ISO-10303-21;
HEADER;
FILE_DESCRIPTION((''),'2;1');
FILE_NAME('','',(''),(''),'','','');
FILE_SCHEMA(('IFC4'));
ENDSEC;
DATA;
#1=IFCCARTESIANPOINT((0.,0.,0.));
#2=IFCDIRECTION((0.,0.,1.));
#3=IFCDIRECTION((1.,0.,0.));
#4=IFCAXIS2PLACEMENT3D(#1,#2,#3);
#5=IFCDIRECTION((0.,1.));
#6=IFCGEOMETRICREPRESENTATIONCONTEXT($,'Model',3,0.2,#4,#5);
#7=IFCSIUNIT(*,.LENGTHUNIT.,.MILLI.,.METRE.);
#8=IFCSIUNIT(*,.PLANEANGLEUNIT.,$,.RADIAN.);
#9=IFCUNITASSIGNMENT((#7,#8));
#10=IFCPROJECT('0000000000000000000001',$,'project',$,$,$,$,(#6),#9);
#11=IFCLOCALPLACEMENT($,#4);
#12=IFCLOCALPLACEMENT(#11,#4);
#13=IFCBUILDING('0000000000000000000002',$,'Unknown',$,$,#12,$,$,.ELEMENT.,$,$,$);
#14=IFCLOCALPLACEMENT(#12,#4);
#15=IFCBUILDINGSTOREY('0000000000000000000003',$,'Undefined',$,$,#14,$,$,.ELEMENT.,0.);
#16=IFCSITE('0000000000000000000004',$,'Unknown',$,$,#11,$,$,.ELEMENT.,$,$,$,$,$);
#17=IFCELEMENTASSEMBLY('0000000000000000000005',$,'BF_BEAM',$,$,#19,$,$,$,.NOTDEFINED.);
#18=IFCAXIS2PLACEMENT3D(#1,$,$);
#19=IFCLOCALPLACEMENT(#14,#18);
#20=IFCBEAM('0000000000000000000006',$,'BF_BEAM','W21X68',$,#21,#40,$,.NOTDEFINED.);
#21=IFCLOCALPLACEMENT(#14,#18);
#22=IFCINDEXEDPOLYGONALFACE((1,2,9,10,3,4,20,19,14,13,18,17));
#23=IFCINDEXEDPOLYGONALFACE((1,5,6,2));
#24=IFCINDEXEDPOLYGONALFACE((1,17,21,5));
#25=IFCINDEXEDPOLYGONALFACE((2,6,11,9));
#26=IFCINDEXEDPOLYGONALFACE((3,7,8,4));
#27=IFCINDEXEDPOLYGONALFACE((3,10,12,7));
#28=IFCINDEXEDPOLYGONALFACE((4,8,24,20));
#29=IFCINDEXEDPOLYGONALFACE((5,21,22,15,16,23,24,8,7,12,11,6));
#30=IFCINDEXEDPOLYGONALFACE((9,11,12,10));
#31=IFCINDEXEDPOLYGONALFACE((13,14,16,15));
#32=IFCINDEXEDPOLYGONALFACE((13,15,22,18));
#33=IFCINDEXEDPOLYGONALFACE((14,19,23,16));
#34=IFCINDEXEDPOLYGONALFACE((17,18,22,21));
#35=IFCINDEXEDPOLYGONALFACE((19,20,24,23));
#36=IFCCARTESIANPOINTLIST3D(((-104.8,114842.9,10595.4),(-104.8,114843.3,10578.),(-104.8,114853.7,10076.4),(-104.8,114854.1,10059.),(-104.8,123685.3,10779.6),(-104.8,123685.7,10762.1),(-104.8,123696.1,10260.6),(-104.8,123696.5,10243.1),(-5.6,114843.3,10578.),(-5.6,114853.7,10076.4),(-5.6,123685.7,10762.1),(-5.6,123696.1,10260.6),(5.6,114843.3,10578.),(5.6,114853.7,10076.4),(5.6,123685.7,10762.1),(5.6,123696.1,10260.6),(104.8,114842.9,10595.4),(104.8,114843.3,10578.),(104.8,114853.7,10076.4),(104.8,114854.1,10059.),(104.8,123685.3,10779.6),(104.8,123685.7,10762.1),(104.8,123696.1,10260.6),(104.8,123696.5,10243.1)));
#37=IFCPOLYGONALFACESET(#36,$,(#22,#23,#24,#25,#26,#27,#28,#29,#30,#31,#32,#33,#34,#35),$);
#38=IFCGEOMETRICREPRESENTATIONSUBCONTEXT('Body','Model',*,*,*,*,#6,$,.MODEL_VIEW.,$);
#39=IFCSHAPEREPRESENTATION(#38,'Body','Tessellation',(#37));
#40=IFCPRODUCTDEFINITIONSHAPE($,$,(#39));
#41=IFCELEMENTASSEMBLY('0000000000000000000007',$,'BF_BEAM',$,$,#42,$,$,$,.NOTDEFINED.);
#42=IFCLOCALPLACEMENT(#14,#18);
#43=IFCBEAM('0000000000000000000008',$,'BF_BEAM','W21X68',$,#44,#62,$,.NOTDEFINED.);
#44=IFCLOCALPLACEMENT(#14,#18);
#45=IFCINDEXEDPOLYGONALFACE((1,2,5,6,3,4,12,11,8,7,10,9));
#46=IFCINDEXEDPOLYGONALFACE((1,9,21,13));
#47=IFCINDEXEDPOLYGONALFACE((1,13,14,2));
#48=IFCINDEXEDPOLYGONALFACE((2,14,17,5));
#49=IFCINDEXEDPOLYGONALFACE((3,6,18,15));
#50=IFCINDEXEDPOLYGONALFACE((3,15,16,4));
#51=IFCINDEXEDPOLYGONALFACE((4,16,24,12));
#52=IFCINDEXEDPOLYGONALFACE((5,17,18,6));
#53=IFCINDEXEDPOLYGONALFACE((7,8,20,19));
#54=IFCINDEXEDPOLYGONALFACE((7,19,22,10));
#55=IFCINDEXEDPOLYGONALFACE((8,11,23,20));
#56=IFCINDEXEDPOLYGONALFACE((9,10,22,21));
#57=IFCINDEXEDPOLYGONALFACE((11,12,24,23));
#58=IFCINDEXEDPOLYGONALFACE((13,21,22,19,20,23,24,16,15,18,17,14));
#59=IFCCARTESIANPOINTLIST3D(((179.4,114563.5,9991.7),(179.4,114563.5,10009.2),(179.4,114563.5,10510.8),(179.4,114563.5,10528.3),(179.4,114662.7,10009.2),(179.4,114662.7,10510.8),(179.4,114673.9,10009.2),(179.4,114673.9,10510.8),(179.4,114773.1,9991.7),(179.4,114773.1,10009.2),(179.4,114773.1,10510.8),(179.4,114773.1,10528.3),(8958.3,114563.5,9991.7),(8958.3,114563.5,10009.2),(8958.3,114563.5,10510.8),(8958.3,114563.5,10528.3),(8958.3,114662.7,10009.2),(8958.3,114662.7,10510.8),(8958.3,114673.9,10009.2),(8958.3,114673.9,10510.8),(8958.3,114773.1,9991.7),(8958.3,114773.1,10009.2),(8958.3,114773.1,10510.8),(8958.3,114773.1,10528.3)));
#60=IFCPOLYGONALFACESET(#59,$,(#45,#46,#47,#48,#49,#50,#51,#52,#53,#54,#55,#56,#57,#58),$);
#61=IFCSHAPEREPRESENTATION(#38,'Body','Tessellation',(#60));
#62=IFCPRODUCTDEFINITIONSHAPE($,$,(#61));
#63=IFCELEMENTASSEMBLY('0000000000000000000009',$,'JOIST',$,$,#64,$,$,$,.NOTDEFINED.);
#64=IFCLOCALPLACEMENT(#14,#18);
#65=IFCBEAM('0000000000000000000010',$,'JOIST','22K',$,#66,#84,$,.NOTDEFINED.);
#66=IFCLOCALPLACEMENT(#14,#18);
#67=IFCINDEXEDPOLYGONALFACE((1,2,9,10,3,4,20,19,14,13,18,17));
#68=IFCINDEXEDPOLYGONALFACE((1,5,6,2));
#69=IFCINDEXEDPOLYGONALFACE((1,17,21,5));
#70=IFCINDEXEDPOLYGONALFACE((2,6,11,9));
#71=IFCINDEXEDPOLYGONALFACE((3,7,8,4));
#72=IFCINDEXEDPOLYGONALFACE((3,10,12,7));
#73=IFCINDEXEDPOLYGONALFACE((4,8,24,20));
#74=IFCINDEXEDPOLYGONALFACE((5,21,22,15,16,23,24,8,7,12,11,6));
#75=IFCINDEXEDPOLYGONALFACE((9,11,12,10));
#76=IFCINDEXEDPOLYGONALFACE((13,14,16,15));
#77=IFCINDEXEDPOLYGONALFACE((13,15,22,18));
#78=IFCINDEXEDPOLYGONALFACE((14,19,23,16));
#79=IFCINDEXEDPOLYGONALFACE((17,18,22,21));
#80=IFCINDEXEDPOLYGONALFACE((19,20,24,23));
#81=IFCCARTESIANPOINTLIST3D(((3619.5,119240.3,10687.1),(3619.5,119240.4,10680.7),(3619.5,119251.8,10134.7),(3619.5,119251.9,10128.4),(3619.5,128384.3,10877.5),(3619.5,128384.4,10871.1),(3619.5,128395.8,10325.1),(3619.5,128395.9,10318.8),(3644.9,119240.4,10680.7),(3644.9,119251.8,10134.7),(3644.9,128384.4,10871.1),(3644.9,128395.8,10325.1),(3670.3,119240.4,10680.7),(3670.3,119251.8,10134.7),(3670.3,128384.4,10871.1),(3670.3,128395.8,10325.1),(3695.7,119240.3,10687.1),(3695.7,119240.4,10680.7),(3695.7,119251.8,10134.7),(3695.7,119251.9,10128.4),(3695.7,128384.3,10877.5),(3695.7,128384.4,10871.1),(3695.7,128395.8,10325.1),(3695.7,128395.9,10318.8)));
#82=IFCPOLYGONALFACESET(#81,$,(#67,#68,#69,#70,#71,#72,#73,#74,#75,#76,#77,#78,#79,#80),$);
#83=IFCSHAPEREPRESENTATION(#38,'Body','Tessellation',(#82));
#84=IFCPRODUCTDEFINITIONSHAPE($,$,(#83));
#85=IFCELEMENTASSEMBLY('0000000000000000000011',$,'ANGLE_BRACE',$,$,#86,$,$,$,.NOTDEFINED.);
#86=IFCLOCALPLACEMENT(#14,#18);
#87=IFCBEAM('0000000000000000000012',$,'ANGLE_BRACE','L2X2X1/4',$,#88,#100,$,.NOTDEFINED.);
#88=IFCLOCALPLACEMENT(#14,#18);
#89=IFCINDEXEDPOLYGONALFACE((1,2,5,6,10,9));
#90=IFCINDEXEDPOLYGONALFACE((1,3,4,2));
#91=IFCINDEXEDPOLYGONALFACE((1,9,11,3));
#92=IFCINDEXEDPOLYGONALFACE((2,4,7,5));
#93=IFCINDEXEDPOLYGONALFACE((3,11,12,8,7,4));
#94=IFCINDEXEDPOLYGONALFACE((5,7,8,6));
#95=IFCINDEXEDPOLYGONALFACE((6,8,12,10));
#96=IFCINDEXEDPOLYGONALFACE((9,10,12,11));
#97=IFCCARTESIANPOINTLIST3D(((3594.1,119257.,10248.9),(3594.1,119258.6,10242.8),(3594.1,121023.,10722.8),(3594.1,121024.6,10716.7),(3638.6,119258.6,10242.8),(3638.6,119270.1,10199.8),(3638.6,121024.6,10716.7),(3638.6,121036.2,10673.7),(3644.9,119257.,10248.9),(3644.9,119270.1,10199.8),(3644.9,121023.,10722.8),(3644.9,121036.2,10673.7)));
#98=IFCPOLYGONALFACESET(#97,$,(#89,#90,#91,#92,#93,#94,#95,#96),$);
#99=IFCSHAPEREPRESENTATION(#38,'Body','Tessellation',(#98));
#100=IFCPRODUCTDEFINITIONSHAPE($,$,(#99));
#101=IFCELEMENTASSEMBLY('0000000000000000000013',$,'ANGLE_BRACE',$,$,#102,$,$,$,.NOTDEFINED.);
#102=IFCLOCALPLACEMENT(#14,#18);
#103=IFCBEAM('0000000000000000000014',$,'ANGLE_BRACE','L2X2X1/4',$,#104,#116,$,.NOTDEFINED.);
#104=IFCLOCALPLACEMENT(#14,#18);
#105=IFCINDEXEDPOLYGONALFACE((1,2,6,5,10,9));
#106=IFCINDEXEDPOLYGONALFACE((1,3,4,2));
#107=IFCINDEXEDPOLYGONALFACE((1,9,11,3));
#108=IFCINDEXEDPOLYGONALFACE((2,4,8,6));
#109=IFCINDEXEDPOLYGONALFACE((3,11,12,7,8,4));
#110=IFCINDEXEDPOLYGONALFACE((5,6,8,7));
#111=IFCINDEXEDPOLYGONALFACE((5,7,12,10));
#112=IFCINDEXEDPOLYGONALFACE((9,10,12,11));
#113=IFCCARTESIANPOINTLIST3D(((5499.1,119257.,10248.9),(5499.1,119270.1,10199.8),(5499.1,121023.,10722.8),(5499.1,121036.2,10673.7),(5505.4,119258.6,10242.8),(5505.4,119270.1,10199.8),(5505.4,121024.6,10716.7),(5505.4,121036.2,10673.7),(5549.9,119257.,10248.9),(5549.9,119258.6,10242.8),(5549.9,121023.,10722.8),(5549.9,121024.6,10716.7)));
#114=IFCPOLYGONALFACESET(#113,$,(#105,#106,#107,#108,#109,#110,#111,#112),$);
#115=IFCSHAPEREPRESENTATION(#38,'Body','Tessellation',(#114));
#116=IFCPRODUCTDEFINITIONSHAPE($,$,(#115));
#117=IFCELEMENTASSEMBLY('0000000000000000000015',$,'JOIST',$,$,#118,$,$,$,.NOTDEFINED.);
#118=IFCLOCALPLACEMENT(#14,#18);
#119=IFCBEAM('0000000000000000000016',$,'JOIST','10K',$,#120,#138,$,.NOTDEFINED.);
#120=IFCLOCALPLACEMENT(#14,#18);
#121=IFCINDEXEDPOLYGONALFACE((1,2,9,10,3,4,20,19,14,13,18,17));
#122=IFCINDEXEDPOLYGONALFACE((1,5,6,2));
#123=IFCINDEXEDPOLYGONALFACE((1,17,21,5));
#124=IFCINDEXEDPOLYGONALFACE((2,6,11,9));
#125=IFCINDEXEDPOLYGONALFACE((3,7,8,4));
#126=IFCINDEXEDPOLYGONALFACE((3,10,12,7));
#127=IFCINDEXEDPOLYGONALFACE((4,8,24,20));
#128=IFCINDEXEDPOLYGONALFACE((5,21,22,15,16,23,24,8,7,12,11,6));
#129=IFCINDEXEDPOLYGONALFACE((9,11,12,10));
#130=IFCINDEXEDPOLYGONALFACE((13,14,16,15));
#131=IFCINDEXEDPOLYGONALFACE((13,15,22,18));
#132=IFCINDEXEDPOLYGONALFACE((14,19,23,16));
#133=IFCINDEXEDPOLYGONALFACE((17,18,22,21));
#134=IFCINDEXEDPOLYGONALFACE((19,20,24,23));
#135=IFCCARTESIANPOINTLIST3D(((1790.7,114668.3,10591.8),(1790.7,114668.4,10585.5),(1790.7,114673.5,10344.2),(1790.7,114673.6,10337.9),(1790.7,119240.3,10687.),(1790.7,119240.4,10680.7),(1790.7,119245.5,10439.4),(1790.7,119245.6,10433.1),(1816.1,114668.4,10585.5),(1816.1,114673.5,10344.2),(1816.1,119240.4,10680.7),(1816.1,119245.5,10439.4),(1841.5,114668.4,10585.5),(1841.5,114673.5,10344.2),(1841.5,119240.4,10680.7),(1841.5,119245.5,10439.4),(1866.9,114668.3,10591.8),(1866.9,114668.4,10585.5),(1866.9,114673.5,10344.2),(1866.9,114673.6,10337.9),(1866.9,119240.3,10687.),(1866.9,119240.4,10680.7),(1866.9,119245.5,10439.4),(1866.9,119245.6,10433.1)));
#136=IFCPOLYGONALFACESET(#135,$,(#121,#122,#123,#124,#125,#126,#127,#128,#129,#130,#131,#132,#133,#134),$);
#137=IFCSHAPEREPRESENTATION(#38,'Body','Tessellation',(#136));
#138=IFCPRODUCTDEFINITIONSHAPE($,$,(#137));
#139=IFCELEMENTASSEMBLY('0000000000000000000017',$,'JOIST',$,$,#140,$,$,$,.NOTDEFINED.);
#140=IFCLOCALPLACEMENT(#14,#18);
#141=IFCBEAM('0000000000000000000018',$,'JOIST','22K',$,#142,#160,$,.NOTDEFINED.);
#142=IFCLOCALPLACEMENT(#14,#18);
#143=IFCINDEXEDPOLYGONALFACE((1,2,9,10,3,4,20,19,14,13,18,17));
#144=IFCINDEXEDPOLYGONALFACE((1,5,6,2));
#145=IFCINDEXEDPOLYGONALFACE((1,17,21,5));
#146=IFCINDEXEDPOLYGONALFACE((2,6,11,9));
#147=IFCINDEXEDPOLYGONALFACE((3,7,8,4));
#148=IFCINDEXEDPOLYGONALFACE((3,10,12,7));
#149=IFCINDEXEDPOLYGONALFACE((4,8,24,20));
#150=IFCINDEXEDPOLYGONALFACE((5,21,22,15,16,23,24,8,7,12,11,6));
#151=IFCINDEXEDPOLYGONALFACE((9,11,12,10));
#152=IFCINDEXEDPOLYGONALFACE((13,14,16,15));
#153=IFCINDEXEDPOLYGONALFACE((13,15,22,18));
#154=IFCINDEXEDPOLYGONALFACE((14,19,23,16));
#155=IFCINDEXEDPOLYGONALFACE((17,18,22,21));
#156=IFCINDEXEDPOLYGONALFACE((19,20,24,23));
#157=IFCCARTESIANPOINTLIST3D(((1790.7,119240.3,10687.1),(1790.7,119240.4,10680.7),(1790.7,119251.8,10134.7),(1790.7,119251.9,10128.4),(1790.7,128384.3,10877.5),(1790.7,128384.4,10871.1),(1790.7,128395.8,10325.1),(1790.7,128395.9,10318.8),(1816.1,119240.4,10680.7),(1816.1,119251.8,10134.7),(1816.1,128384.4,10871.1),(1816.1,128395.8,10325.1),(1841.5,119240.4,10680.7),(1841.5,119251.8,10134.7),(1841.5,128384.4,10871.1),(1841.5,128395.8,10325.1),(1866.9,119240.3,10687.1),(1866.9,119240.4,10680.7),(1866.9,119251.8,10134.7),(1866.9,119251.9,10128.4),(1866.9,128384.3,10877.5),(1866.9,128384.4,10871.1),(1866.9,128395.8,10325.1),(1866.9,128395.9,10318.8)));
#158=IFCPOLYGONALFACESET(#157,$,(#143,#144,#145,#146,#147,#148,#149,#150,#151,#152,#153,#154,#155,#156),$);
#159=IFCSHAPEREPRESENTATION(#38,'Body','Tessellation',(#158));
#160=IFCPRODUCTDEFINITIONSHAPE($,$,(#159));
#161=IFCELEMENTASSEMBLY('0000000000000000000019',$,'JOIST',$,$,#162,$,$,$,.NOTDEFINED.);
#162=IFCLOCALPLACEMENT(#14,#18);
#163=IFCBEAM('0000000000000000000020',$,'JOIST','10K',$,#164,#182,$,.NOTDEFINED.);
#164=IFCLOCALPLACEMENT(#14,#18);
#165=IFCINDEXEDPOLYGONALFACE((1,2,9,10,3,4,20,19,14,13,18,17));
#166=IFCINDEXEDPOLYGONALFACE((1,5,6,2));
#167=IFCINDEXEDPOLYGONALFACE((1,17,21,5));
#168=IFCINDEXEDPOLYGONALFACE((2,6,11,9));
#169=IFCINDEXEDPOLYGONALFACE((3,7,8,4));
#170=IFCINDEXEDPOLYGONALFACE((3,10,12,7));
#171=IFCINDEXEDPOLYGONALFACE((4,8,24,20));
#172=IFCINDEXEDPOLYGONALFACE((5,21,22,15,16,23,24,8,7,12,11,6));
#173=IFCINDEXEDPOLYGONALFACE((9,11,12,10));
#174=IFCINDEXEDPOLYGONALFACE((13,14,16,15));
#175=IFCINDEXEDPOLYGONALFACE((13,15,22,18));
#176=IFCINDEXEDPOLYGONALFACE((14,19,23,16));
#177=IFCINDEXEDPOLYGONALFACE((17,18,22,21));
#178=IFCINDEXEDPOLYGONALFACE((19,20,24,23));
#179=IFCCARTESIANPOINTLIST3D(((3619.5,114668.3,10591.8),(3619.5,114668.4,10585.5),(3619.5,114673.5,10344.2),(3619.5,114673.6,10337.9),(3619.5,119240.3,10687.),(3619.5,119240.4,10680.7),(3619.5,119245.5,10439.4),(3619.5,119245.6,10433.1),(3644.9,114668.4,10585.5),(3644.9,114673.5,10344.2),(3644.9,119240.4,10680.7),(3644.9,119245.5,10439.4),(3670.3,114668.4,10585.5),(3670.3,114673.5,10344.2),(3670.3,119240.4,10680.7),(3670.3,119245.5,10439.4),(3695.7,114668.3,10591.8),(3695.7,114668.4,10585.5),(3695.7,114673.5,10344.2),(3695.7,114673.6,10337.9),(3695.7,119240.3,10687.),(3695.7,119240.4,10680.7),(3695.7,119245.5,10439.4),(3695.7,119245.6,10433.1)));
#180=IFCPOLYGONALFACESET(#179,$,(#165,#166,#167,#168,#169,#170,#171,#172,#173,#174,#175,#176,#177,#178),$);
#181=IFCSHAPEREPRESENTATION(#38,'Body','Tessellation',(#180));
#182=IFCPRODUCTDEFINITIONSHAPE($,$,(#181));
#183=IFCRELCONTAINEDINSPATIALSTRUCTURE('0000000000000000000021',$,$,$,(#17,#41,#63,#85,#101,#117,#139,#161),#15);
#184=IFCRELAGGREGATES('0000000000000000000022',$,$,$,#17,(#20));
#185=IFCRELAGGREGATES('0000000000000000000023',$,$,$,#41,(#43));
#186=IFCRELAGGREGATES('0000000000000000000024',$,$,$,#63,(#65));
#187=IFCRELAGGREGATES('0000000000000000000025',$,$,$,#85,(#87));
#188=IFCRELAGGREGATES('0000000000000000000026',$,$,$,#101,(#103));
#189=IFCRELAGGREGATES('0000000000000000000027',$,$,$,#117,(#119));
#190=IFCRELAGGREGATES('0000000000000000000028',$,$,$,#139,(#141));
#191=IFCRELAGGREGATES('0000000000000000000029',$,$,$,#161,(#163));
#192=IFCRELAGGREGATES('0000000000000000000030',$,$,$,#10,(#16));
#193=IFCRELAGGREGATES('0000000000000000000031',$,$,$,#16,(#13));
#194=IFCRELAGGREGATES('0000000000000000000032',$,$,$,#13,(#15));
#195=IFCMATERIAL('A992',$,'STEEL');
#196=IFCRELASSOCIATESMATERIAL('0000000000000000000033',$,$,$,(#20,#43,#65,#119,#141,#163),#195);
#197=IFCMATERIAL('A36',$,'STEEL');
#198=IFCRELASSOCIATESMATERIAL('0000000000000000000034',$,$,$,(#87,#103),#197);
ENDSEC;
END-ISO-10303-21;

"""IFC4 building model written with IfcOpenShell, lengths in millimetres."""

from ifc_helpers import new_model, si_unit, direction, frame, origin_with_axes, place, context, subcontext, project, spatial, line, indexed_curve, outline, extrude, material, element, aggregate, save


model = new_model("IFC4")

# Units and contexts
model_context = context("Model", 3, precision=0.2, world=origin_with_axes(), true_north=direction((0.0, 1.0)))
body_context = subcontext(model_context, "Body", "Model", "MODEL_VIEW")
ifc_project = project(units=[si_unit("LENGTHUNIT", "METRE", prefix="MILLI"), si_unit("PLANEANGLEUNIT", "RADIAN")], contexts=[model_context])

# Site, building, storey
site_placement = place(None, origin_with_axes())
site = spatial("IfcSite", under=ifc_project, at=site_placement, Name="Unknown", CompositionType="ELEMENT")
building_placement = place(site_placement, origin_with_axes())
building = spatial("IfcBuilding", under=site, at=building_placement, Name="Unknown", CompositionType="ELEMENT")
storey_placement = place(building_placement, origin_with_axes())
storey = spatial("IfcBuildingStorey", under=building, at=storey_placement, Name="Undefined", CompositionType="ELEMENT", Elevation=0.0)

# Element assembly, beam
assembly_1_placement = place(storey_placement, frame((0.0, 114848.5, 10327.2), z_axis=(1.0, 0.0, 0.0), x_axis=(0.0, 0.999783, 0.020819)))
assembly_1 = element("IfcElementAssembly", 1, at=assembly_1_placement, inside=storey, Name="BF_BEAM", PredefinedType="NOTDEFINED")
ifc_material_1 = material(Name="A992", Category="STEEL")
beam_1_placement = place(assembly_1_placement, origin_with_axes())
beam_1 = element("IfcBeam", 2, at=beam_1_placement, material=ifc_material_1, Name="BF_BEAM", Description="W21X68", PredefinedType="NOTDEFINED", context=body_context, shape_type="SolidModel", body=[
    extrude(outline(indexed_curve([(-104.8, -268.3), (104.8, -268.3), (104.8, -250.8), (5.6, -250.8), (5.6, 250.8), (104.8, 250.8), (104.8, 268.3), (-104.8, 268.3), (-104.8, 250.8), (-5.6, 250.8), (-5.6, -250.8), (-104.8, -250.8)], segments=[line(1, 2, 3, 4, 5, 6, 7, 8, 9, 10, 11, 12, 1)])), frame((0.0, 0.0, 0.0), z_axis=(-1.0, 0.0, 0.0), x_axis=(0.0, 0.0, 1.0)), (0.0, 0.0, -1.0), 8844.4),
])
aggregate(assembly_1, [beam_1])

# Element assemblies, beams
assembly_2_placement = place(storey_placement, frame((179.4, 114668.3, 10260.0), z_axis=(0.0, -1.0, 0.0), x_axis=(1.0, 0.0, 0.0)))
assembly_2 = element("IfcElementAssembly", 3, at=assembly_2_placement, inside=storey, Name="BF_BEAM", PredefinedType="NOTDEFINED")
beam_2_placement = place(assembly_2_placement, origin_with_axes())
beam_2 = element("IfcBeam", 4, at=beam_2_placement, material=ifc_material_1, Name="BF_BEAM", Description="W21X68", PredefinedType="NOTDEFINED", context=body_context, shape_type="SolidModel", body=[
    extrude(outline(indexed_curve([(-104.8, -268.3), (104.8, -268.3), (104.8, -250.8), (5.6, -250.8), (5.6, 250.8), (104.8, 250.8), (104.8, 268.3), (-104.8, 268.3), (-104.8, 250.8), (-5.6, 250.8), (-5.6, -250.8), (-104.8, -250.8)], segments=[line(1, 2, 3, 4, 5, 6, 7, 8, 9, 10, 11, 12, 1)])), frame((0.0, 0.0, 0.0), z_axis=(-1.0, 0.0, 0.0), x_axis=(0.0, 0.0, 1.0)), (0.0, 0.0, -1.0), 8778.9),
])
aggregate(assembly_2, [beam_2])
assembly_3_placement = place(storey_placement, frame((3657.6, 119246.1, 10407.7), z_axis=(1.0, 0.0, 0.0), x_axis=(0.0, 0.999783, 0.020819)))
assembly_3 = element("IfcElementAssembly", 5, at=assembly_3_placement, inside=storey, Name="JOIST", PredefinedType="NOTDEFINED")
beam_3_placement = place(assembly_3_placement, origin_with_axes())
beam_3 = element("IfcBeam", 6, at=beam_3_placement, material=ifc_material_1, Name="JOIST", Description="22K", PredefinedType="NOTDEFINED", context=body_context, shape_type="SolidModel", body=[
    extrude(outline(indexed_curve([(-38.1, -279.4), (38.1, -279.4), (38.1, -273.0), (12.7, -273.0), (12.7, 273.0), (38.1, 273.0), (38.1, 279.4), (-38.1, 279.4), (-38.1, 273.0), (-12.7, 273.0), (-12.7, -273.0), (-38.1, -273.0)], segments=[line(1, 2, 3, 4, 5, 6, 7, 8, 9, 10, 11, 12, 1)])), frame((0.0, 0.0, 0.0), z_axis=(-1.0, 0.0, 0.0), x_axis=(0.0, 0.0, 1.0)), (0.0, 0.0, -1.0), 9146.0),
])
aggregate(assembly_3, [beam_3])
assembly_4_placement = place(storey_placement, frame((3619.5, 119263.6, 10224.4), z_axis=(-1.0, 0.0, 0.0), x_axis=(0.0, 0.965831, 0.259174)))
assembly_4 = element("IfcElementAssembly", 7, at=assembly_4_placement, inside=storey, Name="ANGLE_BRACE", PredefinedType="NOTDEFINED")
ifc_material_2 = material(Name="A36", Category="STEEL")
beam_4_placement = place(assembly_4_placement, origin_with_axes())
beam_4 = element("IfcBeam", 8, at=beam_4_placement, material=ifc_material_2, Name="ANGLE_BRACE", Description="L2X2X1/4", PredefinedType="NOTDEFINED", context=body_context, shape_type="SolidModel", body=[
    extrude(outline(indexed_curve([(-25.4, -25.4), (25.4, -25.4), (25.4, -19.1), (-19.1, -19.1), (-19.1, 25.4), (-25.4, 25.4)], segments=[line(1, 2, 3, 4, 5, 6, 1)])), frame((0.0, 0.0, 0.0), z_axis=(-1.0, 0.0, 0.0), x_axis=(0.0, 0.0, 1.0)), (0.0, 0.0, -1.0), 1828.5),
])
aggregate(assembly_4, [beam_4])
assembly_5_placement = place(storey_placement, frame((5524.5, 119263.6, 10224.4), z_axis=(0.0, 0.259174, -0.965831), x_axis=(0.0, 0.965831, 0.259174)))
assembly_5 = element("IfcElementAssembly", 9, at=assembly_5_placement, inside=storey, Name="ANGLE_BRACE", PredefinedType="NOTDEFINED")
beam_5_placement = place(assembly_5_placement, origin_with_axes())
beam_5 = element("IfcBeam", 10, at=beam_5_placement, material=ifc_material_2, Name="ANGLE_BRACE", Description="L2X2X1/4", PredefinedType="NOTDEFINED", context=body_context, shape_type="SolidModel", body=[
    extrude(outline(indexed_curve([(-25.4, -25.4), (25.4, -25.4), (25.4, -19.1), (-19.1, -19.1), (-19.1, 25.4), (-25.4, 25.4)], segments=[line(1, 2, 3, 4, 5, 6, 1)])), frame((0.0, 0.0, 0.0), z_axis=(-1.0, 0.0, 0.0), x_axis=(0.0, 0.0, 1.0)), (0.0, 0.0, -1.0), 1828.5),
])
aggregate(assembly_5, [beam_5])
assembly_6_placement = place(storey_placement, frame((1828.8, 114670.9, 10464.8), z_axis=(1.0, 0.0, 0.0), x_axis=(0.0, 0.999783, 0.020819)))
assembly_6 = element("IfcElementAssembly", 11, at=assembly_6_placement, inside=storey, Name="JOIST", PredefinedType="NOTDEFINED")
beam_6_placement = place(assembly_6_placement, origin_with_axes())
beam_6 = element("IfcBeam", 12, at=beam_6_placement, material=ifc_material_1, Name="JOIST", Description="10K", PredefinedType="NOTDEFINED", context=body_context, shape_type="SolidModel", body=[
    extrude(outline(indexed_curve([(-38.1, -127.0), (38.1, -127.0), (38.1, -120.7), (12.7, -120.7), (12.7, 120.7), (38.1, 120.7), (38.1, 127.0), (-38.1, 127.0), (-38.1, 120.7), (-12.7, 120.7), (-12.7, -120.7), (-38.1, -120.7)], segments=[line(1, 2, 3, 4, 5, 6, 7, 8, 9, 10, 11, 12, 1)])), frame((0.0, 0.0, 0.0), z_axis=(-1.0, 0.0, 0.0), x_axis=(0.0, 0.0, 1.0)), (0.0, 0.0, -1.0), 4573.0),
])
aggregate(assembly_6, [beam_6])
assembly_7_placement = place(storey_placement, frame((1828.8, 119246.1, 10407.7), z_axis=(1.0, 0.0, 0.0), x_axis=(0.0, 0.999783, 0.020819)))
assembly_7 = element("IfcElementAssembly", 13, at=assembly_7_placement, inside=storey, Name="JOIST", PredefinedType="NOTDEFINED")
beam_7_placement = place(assembly_7_placement, origin_with_axes())
beam_7 = element("IfcBeam", 14, at=beam_7_placement, material=ifc_material_1, Name="JOIST", Description="22K", PredefinedType="NOTDEFINED", context=body_context, shape_type="SolidModel", body=[
    extrude(outline(indexed_curve([(-38.1, -279.4), (38.1, -279.4), (38.1, -273.0), (12.7, -273.0), (12.7, 273.0), (38.1, 273.0), (38.1, 279.4), (-38.1, 279.4), (-38.1, 273.0), (-12.7, 273.0), (-12.7, -273.0), (-38.1, -273.0)], segments=[line(1, 2, 3, 4, 5, 6, 7, 8, 9, 10, 11, 12, 1)])), frame((0.0, 0.0, 0.0), z_axis=(-1.0, 0.0, 0.0), x_axis=(0.0, 0.0, 1.0)), (0.0, 0.0, -1.0), 9146.0),
])
aggregate(assembly_7, [beam_7])
assembly_8_placement = place(storey_placement, frame((3657.6, 114670.9, 10464.8), z_axis=(1.0, 0.0, 0.0), x_axis=(0.0, 0.999783, 0.020819)))
assembly_8 = element("IfcElementAssembly", 15, at=assembly_8_placement, inside=storey, Name="JOIST", PredefinedType="NOTDEFINED")
beam_8_placement = place(assembly_8_placement, origin_with_axes())
beam_8 = element("IfcBeam", 16, at=beam_8_placement, material=ifc_material_1, Name="JOIST", Description="10K", PredefinedType="NOTDEFINED", context=body_context, shape_type="SolidModel", body=[
    extrude(outline(indexed_curve([(-38.1, -127.0), (38.1, -127.0), (38.1, -120.7), (12.7, -120.7), (12.7, 120.7), (38.1, 120.7), (38.1, 127.0), (-38.1, 127.0), (-38.1, 120.7), (-12.7, 120.7), (-12.7, -120.7), (-38.1, -120.7)], segments=[line(1, 2, 3, 4, 5, 6, 7, 8, 9, 10, 11, 12, 1)])), frame((0.0, 0.0, 0.0), z_axis=(-1.0, 0.0, 0.0), x_axis=(0.0, 0.0, 1.0)), (0.0, 0.0, -1.0), 4573.0),
])
aggregate(assembly_8, [beam_8])

save(model, "model.ifc")
